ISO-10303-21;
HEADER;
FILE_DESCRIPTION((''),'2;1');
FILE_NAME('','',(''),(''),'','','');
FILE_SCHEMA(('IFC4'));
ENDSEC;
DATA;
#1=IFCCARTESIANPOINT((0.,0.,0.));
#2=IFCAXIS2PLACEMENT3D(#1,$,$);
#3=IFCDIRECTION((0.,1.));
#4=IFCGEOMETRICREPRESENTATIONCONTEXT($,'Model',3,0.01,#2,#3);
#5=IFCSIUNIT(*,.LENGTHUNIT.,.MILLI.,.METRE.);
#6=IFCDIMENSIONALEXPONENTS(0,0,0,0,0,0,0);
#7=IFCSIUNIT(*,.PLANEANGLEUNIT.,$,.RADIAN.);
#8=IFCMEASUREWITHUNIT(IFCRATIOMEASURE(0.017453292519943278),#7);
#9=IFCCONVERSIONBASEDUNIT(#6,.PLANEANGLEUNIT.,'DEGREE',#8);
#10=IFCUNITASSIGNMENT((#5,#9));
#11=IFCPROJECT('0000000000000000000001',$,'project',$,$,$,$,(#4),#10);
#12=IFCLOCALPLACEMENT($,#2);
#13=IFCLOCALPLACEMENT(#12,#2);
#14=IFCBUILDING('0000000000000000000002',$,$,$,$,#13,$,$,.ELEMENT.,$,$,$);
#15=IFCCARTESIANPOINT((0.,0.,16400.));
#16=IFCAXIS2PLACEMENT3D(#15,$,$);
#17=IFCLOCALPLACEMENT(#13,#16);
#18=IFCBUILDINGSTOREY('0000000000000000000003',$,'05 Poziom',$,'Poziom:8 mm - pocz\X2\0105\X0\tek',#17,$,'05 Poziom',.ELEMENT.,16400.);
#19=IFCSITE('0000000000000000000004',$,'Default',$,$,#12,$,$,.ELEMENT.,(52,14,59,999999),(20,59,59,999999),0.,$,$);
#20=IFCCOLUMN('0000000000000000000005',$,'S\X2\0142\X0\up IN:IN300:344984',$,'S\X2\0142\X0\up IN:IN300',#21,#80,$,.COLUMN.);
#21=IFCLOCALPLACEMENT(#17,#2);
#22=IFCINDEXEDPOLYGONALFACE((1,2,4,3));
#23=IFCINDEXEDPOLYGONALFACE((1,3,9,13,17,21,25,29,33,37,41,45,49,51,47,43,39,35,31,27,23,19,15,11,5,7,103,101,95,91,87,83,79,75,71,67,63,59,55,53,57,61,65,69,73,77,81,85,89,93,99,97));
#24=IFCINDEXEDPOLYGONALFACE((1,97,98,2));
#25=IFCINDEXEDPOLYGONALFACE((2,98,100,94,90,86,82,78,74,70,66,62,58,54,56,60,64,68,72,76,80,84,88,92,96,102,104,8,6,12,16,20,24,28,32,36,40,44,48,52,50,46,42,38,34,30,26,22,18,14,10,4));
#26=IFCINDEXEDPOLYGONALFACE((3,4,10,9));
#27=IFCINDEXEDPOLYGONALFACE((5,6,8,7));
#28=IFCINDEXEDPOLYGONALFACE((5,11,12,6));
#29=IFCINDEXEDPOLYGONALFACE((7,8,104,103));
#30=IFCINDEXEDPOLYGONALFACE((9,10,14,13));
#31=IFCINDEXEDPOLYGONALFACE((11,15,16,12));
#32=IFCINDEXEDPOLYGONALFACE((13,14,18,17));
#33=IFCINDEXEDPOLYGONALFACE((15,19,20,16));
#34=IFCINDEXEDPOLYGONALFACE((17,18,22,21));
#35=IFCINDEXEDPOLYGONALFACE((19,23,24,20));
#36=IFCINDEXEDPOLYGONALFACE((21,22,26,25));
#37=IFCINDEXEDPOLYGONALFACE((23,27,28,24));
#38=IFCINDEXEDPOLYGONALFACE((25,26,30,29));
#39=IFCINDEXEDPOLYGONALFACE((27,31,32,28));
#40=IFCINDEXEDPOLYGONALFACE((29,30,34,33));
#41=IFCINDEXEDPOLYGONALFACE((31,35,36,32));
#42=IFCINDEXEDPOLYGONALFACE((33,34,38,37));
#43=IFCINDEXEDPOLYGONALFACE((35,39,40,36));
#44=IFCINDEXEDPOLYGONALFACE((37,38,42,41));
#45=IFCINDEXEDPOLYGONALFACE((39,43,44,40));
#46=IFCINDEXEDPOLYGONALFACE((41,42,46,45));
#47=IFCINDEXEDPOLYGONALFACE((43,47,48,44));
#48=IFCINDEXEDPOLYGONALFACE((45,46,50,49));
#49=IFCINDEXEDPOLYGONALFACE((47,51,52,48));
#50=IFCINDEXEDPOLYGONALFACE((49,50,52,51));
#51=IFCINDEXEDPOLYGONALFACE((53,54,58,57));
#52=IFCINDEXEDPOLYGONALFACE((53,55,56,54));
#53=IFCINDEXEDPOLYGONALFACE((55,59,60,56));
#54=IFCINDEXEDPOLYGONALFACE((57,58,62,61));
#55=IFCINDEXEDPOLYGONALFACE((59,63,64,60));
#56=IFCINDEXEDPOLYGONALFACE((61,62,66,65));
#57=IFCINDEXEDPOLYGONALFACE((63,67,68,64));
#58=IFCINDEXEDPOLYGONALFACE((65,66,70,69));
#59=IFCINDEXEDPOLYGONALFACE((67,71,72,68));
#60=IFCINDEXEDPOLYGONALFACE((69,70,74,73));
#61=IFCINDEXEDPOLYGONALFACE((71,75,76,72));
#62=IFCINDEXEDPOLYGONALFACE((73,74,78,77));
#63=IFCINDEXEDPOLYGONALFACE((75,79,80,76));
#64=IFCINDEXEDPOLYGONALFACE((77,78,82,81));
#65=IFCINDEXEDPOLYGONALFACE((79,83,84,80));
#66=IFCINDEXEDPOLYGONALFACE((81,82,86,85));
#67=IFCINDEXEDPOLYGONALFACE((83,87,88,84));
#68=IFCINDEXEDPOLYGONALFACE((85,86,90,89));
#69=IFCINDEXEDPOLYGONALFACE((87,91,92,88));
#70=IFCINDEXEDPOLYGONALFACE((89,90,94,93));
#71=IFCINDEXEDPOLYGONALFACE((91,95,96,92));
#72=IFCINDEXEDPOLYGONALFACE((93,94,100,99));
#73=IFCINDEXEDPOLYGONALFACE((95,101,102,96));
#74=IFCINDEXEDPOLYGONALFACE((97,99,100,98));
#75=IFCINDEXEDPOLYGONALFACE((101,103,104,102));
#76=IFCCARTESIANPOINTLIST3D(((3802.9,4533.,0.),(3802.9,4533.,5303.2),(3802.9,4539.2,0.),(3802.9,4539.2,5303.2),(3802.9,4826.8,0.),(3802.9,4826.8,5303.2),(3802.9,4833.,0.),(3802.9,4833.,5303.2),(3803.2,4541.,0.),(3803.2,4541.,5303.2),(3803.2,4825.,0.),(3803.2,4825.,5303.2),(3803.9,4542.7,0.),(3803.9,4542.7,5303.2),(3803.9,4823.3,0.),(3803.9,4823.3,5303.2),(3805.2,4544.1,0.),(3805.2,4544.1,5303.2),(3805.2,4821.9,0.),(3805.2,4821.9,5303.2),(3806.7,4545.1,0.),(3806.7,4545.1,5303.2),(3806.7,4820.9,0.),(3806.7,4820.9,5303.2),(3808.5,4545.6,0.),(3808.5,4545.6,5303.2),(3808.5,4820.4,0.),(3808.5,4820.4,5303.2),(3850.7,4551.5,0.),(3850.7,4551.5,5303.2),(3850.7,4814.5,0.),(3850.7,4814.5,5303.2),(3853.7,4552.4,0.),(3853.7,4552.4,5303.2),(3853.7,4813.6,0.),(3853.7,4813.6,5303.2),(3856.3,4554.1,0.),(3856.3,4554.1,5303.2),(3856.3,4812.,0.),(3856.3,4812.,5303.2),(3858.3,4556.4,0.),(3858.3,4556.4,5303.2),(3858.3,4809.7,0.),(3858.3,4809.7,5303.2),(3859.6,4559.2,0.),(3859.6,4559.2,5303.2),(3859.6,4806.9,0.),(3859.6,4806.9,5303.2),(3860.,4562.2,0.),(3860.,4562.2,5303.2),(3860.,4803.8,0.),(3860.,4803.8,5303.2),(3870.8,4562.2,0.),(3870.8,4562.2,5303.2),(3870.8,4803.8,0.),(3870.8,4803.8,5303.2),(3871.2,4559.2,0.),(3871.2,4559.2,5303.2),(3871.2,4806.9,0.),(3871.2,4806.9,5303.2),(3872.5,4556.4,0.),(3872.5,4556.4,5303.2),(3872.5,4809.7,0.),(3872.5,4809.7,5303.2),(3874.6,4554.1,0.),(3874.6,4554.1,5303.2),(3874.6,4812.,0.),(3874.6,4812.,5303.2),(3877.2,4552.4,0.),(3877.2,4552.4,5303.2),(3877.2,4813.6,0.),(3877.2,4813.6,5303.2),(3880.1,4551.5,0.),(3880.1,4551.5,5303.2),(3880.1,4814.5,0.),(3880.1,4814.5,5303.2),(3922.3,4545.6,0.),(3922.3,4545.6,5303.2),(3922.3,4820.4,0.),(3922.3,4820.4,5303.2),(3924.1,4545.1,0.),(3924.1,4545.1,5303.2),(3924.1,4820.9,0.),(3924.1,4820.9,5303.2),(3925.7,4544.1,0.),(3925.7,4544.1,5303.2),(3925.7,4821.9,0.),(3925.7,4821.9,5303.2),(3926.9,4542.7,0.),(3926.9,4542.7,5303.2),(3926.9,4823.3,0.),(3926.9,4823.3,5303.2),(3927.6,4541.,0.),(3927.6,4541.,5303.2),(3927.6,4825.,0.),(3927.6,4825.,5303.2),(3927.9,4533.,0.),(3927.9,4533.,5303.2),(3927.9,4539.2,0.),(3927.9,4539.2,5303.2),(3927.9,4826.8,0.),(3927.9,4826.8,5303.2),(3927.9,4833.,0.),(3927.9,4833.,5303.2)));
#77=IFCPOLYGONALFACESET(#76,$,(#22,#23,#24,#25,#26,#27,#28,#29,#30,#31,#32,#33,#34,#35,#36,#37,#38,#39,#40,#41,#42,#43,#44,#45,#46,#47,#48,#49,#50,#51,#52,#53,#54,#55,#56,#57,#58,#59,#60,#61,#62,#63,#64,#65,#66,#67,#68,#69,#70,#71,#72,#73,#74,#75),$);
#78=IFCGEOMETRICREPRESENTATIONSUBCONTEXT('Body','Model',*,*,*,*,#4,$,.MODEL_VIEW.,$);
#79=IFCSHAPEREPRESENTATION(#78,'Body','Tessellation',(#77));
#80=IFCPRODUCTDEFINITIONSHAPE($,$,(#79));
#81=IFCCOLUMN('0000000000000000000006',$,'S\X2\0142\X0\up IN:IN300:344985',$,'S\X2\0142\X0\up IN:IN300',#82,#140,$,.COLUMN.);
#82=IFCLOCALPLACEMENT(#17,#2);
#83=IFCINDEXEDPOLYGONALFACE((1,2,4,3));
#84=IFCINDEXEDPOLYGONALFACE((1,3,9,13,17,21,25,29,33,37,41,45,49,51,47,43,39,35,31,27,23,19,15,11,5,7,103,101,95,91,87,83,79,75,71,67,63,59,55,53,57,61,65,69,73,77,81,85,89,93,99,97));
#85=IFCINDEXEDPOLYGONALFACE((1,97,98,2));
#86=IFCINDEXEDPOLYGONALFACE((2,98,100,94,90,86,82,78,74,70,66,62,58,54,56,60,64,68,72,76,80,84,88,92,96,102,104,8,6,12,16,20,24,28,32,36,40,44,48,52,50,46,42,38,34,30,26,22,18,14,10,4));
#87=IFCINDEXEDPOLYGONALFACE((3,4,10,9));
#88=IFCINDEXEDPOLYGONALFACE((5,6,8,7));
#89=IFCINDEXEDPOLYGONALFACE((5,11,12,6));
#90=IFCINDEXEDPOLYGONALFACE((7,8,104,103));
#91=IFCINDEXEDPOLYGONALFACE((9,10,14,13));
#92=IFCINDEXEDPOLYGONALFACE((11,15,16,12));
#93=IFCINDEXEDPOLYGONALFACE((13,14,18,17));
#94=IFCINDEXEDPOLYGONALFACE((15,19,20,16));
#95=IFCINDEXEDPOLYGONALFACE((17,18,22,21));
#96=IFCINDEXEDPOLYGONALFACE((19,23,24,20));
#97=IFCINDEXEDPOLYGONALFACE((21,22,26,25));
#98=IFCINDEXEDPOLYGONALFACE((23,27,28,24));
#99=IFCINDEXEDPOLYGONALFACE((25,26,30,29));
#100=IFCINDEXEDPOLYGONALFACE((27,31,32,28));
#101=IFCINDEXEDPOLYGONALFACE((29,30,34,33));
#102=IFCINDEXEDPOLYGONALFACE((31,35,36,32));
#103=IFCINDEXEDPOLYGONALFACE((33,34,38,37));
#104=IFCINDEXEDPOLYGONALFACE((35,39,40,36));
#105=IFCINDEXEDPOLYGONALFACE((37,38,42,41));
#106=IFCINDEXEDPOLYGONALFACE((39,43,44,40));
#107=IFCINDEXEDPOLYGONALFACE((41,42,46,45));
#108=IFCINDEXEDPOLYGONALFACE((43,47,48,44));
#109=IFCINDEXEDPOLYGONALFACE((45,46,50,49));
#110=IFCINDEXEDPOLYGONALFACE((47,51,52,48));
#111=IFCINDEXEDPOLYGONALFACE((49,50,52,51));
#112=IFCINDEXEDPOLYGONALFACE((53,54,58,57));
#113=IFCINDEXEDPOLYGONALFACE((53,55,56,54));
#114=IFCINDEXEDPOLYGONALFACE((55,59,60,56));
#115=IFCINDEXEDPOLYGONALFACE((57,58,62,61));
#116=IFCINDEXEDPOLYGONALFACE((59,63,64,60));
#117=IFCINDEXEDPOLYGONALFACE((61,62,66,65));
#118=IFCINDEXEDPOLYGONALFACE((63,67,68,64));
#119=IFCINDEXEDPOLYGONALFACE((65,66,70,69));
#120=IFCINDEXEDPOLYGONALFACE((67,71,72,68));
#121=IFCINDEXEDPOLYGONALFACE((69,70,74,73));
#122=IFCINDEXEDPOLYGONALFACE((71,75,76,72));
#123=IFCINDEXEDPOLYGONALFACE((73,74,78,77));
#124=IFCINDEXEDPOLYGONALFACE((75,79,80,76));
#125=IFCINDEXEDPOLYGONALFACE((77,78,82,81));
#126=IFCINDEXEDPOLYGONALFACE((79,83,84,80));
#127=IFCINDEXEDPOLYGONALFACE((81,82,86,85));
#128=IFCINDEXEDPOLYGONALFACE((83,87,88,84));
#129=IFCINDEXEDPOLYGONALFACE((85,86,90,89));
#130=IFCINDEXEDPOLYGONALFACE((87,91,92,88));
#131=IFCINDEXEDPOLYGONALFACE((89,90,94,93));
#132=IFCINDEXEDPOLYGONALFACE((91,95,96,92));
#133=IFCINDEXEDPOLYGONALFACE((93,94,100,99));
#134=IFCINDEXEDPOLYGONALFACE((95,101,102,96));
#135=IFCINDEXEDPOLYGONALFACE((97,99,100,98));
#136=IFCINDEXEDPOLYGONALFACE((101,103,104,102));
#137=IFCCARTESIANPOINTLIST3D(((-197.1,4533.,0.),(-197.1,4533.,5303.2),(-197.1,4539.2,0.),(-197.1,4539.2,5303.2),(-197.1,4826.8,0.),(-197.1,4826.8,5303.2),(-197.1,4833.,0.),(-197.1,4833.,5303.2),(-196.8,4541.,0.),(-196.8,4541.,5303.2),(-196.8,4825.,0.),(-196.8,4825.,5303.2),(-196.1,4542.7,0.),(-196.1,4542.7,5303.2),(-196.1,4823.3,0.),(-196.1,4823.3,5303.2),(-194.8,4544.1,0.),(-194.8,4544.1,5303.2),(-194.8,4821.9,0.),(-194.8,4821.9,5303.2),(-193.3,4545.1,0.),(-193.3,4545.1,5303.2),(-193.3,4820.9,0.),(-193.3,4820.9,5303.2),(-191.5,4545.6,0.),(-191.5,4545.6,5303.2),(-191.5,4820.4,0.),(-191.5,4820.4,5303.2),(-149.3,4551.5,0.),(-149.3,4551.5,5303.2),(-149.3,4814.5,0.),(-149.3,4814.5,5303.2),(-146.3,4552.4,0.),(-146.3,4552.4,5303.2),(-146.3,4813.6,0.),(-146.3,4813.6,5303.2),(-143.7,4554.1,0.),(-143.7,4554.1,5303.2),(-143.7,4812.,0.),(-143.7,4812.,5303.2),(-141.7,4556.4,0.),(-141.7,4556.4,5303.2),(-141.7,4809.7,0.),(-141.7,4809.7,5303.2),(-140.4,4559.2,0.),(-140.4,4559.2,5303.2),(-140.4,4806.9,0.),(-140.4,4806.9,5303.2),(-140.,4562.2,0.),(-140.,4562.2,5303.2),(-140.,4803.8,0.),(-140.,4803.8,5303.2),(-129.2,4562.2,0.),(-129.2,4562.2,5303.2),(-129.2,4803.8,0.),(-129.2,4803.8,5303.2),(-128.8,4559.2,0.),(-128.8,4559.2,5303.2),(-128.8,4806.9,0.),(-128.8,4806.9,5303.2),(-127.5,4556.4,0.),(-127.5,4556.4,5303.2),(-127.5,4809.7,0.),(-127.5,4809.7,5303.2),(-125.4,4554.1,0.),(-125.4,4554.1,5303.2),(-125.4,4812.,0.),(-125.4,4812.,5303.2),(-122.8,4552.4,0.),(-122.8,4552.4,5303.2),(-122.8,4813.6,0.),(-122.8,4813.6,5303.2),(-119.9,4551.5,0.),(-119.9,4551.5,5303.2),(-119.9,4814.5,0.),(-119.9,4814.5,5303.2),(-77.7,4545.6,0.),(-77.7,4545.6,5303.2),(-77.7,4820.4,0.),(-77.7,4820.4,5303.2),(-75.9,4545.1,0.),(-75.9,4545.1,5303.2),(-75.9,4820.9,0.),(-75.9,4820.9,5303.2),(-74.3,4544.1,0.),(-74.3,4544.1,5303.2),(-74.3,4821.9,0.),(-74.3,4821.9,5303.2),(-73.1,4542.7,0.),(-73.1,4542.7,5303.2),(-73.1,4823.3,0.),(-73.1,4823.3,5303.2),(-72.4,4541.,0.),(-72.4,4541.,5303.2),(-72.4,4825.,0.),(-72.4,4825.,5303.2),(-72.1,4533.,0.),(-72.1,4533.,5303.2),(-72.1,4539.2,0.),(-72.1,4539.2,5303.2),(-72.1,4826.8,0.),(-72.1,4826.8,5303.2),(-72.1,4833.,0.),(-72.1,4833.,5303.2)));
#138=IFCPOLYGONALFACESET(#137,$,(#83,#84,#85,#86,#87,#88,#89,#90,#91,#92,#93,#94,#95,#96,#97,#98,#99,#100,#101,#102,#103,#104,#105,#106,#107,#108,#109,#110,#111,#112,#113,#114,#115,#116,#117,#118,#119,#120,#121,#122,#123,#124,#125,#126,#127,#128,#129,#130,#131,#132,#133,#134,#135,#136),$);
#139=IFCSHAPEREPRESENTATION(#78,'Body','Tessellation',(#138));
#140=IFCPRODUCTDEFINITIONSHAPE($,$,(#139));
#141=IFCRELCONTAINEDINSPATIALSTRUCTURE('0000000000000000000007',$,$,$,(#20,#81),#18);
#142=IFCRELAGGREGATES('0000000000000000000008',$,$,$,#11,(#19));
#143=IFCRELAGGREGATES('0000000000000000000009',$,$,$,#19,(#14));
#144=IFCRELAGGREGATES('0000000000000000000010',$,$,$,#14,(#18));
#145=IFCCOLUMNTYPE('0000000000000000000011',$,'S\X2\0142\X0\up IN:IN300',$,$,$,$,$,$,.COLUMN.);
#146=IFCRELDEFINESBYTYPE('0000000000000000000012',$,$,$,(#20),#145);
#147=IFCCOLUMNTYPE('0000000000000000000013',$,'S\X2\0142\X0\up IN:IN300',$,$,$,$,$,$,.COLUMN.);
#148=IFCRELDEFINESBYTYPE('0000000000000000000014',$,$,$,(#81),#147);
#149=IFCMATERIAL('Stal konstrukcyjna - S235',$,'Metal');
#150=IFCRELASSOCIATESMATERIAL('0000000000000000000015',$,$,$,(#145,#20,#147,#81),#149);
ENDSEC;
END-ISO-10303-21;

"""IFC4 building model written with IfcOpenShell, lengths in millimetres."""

from ifc_helpers import new_model, entity, si_unit, converted_unit, direction, frame, origin, place, context, subcontext, project, spatial, line, arc, indexed_curve, outline, extrude, source, transform, mapped, material, type_object, type_shapes, element, save


model = new_model("IFC4")

# Units and contexts
model_context = context("Model", 3, precision=0.01, world=origin(), true_north=direction((0.0, 1.0)))
body_context = subcontext(model_context, "Body", "Model", "MODEL_VIEW")
ifc_project = project(units=[si_unit("LENGTHUNIT", "METRE", prefix="MILLI"), converted_unit("PLANEANGLEUNIT", "DEGREE", entity("IfcRatioMeasure", 0.017453292519943278), si_unit("PLANEANGLEUNIT", "RADIAN"), dimensions=[0, 0, 0, 0, 0, 0, 0])], contexts=[model_context])

# Site, building, storey
site_placement = place(None, origin())
site = spatial("IfcSite", under=ifc_project, at=site_placement, Name="Default", CompositionType="ELEMENT", RefLatitude=(52, 14, 59, 999999), RefLongitude=(20, 59, 59, 999999), RefElevation=0.0)
building_placement = place(site_placement, origin())
building = spatial("IfcBuilding", under=site, at=building_placement, CompositionType="ELEMENT")
storey_placement = place(building_placement, frame((0.0, 0.0, 16400.0)))
storey = spatial("IfcBuildingStorey", under=building, at=storey_placement, Name="05 Poziom", ObjectType="Poziom:8 mm - początek", LongName="05 Poziom", CompositionType="ELEMENT", Elevation=16400.0)

# Columns
ifc_material = material(Name="Stal konstrukcyjna - S235", Category="Metal")
column_type_1 = type_object("IfcColumnType", Name="Słup IN:IN300", PredefinedType="COLUMN", material=ifc_material)
shared_shape_1 = source(origin(), body_context, "Body", "SweptSolid", [
    extrude(outline(indexed_curve([(143.8, -62.5), (150.0, -62.5), (150.0, 62.5), (143.8, 62.5), (139.6, 60.9), (137.4, 56.9), (131.5, 14.7), (127.9, 8.1), (120.8, 5.4), (-120.8, 5.4), (-127.9, 8.1), (-131.5, 14.7), (-137.4, 56.9), (-139.6, 60.9), (-143.8, 62.5), (-150.0, 62.5), (-150.0, -62.5), (-143.8, -62.5), (-139.6, -60.9), (-137.4, -56.9), (-131.5, -14.7), (-127.9, -8.1), (-120.8, -5.4), (120.8, -5.4), (127.9, -8.1), (131.5, -14.7), (137.4, -56.9), (139.6, -60.9)], segments=[line(1, 2, 3, 4), arc(4, 5, 6), line(6, 7), arc(7, 8, 9), line(9, 10), arc(10, 11, 12), line(12, 13), arc(13, 14, 15), line(15, 16, 17, 18), arc(18, 19, 20), line(20, 21), arc(21, 22, 23), line(23, 24), arc(24, 25, 26), line(26, 27), arc(27, 28, 1)], self_intersect=False)), frame((3865.4, 4683.0, 16400.0), z_axis=(0.0, 0.0, 1.0), x_axis=(0.0, -1.0, 0.0)), (0.0, 0.0, 1.0), 5303.2),
])
type_shapes(column_type_1, [shared_shape_1])
column_1_placement = place(storey_placement, frame((0.0, 0.0, -16400.0)))
element("IfcColumn", 1, at=column_1_placement, inside=storey, type_object=column_type_1, material=ifc_material, Name="Słup IN:IN300:344984", ObjectType="Słup IN:IN300", PredefinedType="COLUMN", context=body_context, shape_type="MappedRepresentation", body=[
    mapped(shared_shape_1, transform((0.0, 0.0, 0.0), scale=1.0)),
])
column_type_2 = type_object("IfcColumnType", Name="Słup IN:IN300", PredefinedType="COLUMN", material=ifc_material)
shared_shape_2 = source(origin(), body_context, "Body", "SweptSolid", [
    extrude(outline(indexed_curve([(143.8, -62.5), (150.0, -62.5), (150.0, 62.5), (143.8, 62.5), (139.6, 60.9), (137.4, 56.9), (131.5, 14.7), (127.9, 8.1), (120.8, 5.4), (-120.8, 5.4), (-127.9, 8.1), (-131.5, 14.7), (-137.4, 56.9), (-139.6, 60.9), (-143.8, 62.5), (-150.0, 62.5), (-150.0, -62.5), (-143.8, -62.5), (-139.6, -60.9), (-137.4, -56.9), (-131.5, -14.7), (-127.9, -8.1), (-120.8, -5.4), (120.8, -5.4), (127.9, -8.1), (131.5, -14.7), (137.4, -56.9), (139.6, -60.9)], segments=[line(1, 2, 3, 4), arc(4, 5, 6), line(6, 7), arc(7, 8, 9), line(9, 10), arc(10, 11, 12), line(12, 13), arc(13, 14, 15), line(15, 16, 17, 18), arc(18, 19, 20), line(20, 21), arc(21, 22, 23), line(23, 24), arc(24, 25, 26), line(26, 27), arc(27, 28, 1)], self_intersect=False)), frame((-134.6, 4683.0, 16400.0), z_axis=(0.0, 0.0, 1.0), x_axis=(0.0, -1.0, 0.0)), (0.0, 0.0, 1.0), 5303.2),
])
type_shapes(column_type_2, [shared_shape_2])
column_2_placement = place(storey_placement, frame((0.0, 0.0, -16400.0)))
element("IfcColumn", 2, at=column_2_placement, inside=storey, type_object=column_type_2, material=ifc_material, Name="Słup IN:IN300:344985", ObjectType="Słup IN:IN300", PredefinedType="COLUMN", context=body_context, shape_type="MappedRepresentation", body=[
    mapped(shared_shape_2, transform((0.0, 0.0, 0.0), scale=1.0)),
])

save(model, "model.ifc")
